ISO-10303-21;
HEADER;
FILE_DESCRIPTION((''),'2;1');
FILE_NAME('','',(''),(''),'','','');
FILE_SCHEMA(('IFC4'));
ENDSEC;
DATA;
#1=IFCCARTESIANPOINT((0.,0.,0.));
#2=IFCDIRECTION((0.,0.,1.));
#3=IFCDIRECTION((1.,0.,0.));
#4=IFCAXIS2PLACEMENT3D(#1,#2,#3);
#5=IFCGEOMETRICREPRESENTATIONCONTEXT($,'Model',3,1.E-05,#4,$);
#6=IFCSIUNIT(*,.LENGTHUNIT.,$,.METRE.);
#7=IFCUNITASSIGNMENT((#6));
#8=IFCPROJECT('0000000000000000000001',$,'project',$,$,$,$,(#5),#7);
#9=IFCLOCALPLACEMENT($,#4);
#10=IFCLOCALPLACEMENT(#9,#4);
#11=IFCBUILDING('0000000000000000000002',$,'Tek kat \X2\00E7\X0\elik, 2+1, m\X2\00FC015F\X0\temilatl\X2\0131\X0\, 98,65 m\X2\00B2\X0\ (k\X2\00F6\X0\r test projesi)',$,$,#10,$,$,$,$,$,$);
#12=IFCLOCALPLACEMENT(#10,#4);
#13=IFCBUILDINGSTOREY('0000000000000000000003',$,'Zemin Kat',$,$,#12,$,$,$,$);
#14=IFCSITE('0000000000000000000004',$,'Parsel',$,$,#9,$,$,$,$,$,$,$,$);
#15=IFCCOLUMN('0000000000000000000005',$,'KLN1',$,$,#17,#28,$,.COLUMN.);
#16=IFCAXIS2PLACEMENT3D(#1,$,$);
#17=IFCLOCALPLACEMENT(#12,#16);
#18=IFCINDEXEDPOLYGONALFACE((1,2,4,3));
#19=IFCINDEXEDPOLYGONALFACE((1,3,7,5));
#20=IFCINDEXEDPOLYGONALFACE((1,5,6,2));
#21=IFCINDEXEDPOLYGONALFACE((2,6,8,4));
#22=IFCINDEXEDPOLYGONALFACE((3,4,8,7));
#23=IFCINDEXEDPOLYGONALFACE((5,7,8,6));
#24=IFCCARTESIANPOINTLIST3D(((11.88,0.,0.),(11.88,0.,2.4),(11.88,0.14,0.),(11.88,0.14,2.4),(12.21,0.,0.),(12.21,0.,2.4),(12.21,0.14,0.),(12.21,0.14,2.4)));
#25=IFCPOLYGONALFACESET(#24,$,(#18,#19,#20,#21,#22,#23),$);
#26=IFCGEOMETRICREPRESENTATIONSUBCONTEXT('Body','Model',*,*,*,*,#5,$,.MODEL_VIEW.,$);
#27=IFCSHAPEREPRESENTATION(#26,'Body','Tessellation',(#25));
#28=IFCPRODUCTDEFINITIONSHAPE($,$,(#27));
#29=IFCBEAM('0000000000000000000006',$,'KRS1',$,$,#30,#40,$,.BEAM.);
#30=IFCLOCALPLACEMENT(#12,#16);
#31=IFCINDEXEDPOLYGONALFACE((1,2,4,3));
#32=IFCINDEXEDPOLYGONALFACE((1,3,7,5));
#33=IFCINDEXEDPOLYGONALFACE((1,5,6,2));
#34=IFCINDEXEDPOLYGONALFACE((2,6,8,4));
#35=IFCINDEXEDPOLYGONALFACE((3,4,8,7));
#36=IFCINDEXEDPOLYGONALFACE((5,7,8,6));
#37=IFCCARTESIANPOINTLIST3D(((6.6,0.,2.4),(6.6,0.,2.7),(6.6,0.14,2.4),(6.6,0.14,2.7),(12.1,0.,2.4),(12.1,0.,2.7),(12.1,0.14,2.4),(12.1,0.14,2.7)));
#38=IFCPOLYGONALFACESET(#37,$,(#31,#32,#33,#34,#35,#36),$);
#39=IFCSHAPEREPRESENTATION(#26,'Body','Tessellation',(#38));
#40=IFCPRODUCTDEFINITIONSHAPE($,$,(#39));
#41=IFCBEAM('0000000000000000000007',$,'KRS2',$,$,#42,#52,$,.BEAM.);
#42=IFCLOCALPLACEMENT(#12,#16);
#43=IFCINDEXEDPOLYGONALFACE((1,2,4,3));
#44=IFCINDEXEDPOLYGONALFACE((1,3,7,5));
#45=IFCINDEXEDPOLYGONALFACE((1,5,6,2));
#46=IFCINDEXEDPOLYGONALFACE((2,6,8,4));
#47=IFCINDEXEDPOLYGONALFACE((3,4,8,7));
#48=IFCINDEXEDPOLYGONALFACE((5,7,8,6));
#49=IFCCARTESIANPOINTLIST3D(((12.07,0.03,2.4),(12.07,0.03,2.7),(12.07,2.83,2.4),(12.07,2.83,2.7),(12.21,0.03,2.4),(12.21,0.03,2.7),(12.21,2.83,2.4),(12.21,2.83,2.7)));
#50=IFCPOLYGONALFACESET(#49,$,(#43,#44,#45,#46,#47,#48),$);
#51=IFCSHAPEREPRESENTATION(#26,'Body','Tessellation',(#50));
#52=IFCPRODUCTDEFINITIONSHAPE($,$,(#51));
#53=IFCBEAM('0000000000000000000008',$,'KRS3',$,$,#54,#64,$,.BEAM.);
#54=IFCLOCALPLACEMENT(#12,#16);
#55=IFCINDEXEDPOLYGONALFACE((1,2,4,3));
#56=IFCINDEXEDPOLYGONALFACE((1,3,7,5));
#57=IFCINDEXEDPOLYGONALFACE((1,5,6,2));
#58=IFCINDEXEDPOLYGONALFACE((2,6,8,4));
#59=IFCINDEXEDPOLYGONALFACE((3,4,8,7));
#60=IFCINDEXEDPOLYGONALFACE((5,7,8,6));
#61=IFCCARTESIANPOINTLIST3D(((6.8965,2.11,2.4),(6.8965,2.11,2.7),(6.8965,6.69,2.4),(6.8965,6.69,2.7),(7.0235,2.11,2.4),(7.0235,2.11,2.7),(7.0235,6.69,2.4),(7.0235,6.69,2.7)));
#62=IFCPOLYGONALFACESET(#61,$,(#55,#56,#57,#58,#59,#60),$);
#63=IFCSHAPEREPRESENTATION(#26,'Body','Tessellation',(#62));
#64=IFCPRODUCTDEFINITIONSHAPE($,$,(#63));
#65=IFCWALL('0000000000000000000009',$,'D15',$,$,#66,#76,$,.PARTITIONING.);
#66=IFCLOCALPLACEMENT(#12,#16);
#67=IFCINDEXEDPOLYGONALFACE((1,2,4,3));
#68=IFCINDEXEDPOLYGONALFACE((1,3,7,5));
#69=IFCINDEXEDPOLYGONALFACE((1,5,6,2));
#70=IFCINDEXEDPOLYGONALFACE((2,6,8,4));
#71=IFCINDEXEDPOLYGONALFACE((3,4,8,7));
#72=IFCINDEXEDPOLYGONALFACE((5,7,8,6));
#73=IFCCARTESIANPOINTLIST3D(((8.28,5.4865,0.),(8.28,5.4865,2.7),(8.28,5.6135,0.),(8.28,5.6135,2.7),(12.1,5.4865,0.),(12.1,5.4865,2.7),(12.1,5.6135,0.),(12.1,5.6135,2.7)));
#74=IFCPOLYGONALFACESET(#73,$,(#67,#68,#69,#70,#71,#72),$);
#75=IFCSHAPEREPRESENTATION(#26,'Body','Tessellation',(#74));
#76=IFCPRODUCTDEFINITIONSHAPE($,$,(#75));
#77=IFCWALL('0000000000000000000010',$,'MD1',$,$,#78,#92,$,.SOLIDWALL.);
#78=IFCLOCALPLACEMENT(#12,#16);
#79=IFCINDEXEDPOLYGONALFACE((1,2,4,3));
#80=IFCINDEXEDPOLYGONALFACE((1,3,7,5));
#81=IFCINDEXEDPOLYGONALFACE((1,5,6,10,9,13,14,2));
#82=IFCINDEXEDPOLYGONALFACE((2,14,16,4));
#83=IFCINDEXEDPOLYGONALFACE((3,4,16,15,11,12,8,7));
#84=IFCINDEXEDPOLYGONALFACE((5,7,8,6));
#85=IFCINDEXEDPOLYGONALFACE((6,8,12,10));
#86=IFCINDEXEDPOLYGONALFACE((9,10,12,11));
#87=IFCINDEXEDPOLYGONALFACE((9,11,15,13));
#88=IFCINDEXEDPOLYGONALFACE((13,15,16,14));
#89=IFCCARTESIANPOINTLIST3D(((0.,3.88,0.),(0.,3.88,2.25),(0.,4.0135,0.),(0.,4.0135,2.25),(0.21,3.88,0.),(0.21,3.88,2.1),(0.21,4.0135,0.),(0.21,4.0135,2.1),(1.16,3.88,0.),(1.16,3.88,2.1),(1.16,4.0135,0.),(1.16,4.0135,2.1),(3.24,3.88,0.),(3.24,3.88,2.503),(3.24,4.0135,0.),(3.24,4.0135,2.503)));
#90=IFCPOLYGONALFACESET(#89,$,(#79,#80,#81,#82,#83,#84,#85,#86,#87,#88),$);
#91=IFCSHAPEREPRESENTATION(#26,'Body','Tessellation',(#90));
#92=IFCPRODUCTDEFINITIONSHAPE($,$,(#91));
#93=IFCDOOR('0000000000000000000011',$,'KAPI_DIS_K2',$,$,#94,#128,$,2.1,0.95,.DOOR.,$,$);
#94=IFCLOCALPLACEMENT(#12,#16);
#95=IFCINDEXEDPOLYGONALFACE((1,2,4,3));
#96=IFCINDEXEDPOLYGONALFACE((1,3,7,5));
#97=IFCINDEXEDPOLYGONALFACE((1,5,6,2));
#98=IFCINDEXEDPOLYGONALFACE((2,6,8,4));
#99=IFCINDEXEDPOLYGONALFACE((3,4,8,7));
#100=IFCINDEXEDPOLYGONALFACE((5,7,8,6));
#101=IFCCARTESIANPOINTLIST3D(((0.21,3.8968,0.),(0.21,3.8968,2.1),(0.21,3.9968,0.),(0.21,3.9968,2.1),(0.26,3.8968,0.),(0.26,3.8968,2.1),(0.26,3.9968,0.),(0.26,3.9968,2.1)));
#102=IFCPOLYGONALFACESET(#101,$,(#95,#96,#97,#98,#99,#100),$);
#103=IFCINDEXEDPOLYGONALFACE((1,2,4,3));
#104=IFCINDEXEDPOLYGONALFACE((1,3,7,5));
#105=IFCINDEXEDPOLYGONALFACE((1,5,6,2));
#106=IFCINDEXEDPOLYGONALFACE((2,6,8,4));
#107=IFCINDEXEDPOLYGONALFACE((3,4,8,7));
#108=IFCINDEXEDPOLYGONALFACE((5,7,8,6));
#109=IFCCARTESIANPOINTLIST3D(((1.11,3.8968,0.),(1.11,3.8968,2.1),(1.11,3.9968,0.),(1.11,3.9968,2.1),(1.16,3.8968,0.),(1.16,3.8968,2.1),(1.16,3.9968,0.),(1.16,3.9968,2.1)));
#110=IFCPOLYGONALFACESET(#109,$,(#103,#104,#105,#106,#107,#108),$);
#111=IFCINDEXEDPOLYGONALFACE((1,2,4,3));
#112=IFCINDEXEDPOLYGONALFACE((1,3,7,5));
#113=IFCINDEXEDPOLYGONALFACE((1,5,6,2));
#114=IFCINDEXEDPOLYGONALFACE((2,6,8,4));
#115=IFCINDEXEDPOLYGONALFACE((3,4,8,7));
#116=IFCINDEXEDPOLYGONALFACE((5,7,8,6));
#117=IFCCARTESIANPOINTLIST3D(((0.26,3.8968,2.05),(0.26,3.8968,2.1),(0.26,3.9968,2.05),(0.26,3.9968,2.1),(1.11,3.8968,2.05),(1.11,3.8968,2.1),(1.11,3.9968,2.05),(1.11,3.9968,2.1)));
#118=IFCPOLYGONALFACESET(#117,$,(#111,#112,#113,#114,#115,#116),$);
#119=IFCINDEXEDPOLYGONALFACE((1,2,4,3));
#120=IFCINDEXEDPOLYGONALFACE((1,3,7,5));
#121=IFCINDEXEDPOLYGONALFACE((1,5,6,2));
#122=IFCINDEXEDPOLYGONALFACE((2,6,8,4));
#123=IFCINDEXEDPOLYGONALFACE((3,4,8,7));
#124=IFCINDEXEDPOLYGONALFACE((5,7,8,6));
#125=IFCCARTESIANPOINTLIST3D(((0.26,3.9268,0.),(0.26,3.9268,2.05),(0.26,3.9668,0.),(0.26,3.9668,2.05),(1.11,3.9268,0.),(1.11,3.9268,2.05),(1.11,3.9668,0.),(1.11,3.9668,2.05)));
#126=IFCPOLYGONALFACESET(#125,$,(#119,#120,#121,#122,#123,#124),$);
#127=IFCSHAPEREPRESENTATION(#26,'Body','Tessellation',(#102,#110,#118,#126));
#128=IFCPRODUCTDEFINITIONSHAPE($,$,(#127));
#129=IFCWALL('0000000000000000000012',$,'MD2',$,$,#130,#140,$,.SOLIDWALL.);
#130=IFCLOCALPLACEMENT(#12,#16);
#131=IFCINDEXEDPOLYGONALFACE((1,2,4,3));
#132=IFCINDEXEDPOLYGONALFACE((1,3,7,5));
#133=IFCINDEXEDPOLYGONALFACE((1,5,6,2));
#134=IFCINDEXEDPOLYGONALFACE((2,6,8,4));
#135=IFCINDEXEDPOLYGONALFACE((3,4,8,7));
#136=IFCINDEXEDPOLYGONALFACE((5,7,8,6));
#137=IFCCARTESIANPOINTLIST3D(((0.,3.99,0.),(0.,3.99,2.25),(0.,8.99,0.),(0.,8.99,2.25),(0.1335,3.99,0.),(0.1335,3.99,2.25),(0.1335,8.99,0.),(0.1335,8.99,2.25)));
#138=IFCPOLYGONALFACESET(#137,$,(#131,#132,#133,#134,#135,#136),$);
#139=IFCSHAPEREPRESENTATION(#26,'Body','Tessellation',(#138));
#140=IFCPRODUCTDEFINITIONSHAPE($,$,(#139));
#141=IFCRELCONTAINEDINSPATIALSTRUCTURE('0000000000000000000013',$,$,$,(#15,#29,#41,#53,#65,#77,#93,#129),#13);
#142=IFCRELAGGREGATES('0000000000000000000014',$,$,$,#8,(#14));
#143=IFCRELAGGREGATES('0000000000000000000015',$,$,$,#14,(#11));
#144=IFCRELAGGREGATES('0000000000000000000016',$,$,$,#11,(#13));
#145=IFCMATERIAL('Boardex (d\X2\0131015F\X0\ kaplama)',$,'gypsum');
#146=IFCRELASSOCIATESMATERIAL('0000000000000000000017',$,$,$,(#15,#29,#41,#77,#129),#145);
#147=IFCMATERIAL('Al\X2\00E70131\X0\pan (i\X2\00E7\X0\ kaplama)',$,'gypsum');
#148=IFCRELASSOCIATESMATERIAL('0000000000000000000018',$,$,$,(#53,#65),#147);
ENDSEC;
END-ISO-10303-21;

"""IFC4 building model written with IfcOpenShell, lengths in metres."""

from ifc_helpers import new_model, si_unit, frame, origin_with_axes, place, context, subcontext, project, spatial, line, indexed_curve, outline, extrude, material, element, fill, save


model = new_model("IFC4")

# Units and contexts
model_context = context("Model", 3, precision=1e-05, world=origin_with_axes())
body_context = subcontext(model_context, "Body", "Model", "MODEL_VIEW")
ifc_project = project(units=[si_unit("LENGTHUNIT", "METRE")], contexts=[model_context])

# Site, building, storey
site_placement = place(None, origin_with_axes())
site = spatial("IfcSite", under=ifc_project, at=site_placement, Name="Parsel")
building_placement = place(site_placement, origin_with_axes())
building = spatial("IfcBuilding", under=site, at=building_placement, Name="Tek kat çelik, 2+1, müştemilatlı, 98,65 m² (kör test projesi)")
storey_placement = place(building_placement, origin_with_axes())
storey = spatial("IfcBuildingStorey", under=building, at=storey_placement, Name="Zemin Kat")

# Column
ifc_material_1 = material(Name="Boardex (dış kaplama)", Category="gypsum")
column_placement = place(storey_placement, origin_with_axes())
element("IfcColumn", 1, at=column_placement, inside=storey, material=ifc_material_1, Name="KLN1", PredefinedType="COLUMN", context=body_context, shape_type="SweptSolid", body=[
    extrude(outline(indexed_curve([(0.0, 0.0), (0.33, 0.0), (0.33, 0.14), (0.0, 0.14)], segments=[line(1, 2, 3, 4, 1)])), frame((11.88, 0.0, 0.0), z_axis=(0.0, 0.0, 1.0), x_axis=(1.0, 0.0, 0.0)), (0.0, 0.0, 1.0), 2.4),
])

# Beams
beam_1_placement = place(storey_placement, origin_with_axes())
element("IfcBeam", 2, at=beam_1_placement, inside=storey, material=ifc_material_1, Name="KRS1", PredefinedType="BEAM", context=body_context, shape_type="SweptSolid", body=[
    extrude(outline(indexed_curve([(0.0, 0.0), (5.5, 0.0), (5.5, 0.14), (0.0, 0.14)], segments=[line(1, 2, 3, 4, 1)])), frame((6.6, 0.0, 2.4), z_axis=(0.0, 0.0, 1.0), x_axis=(1.0, 0.0, 0.0)), (0.0, 0.0, 1.0), 0.3),
])
beam_2_placement = place(storey_placement, origin_with_axes())
element("IfcBeam", 3, at=beam_2_placement, inside=storey, material=ifc_material_1, Name="KRS2", PredefinedType="BEAM", context=body_context, shape_type="SweptSolid", body=[
    extrude(outline(indexed_curve([(0.0, 0.0), (0.14, 0.0), (0.14, 2.8), (0.0, 2.8)], segments=[line(1, 2, 3, 4, 1)])), frame((12.07, 0.03, 2.4), z_axis=(0.0, 0.0, 1.0), x_axis=(1.0, 0.0, 0.0)), (0.0, 0.0, 1.0), 0.3),
])
ifc_material_2 = material(Name="Alçıpan (iç kaplama)", Category="gypsum")
beam_3_placement = place(storey_placement, origin_with_axes())
element("IfcBeam", 4, at=beam_3_placement, inside=storey, material=ifc_material_2, Name="KRS3", PredefinedType="BEAM", context=body_context, shape_type="SweptSolid", body=[
    extrude(outline(indexed_curve([(0.0, 0.0), (0.127, 0.0), (0.127, 4.58), (0.0, 4.58)], segments=[line(1, 2, 3, 4, 1)])), frame((6.8965, 2.11, 2.4), z_axis=(0.0, 0.0, 1.0), x_axis=(1.0, 0.0, 0.0)), (0.0, 0.0, 1.0), 0.3),
])

# Wall
wall_1_placement = place(storey_placement, origin_with_axes())
element("IfcWall", 5, at=wall_1_placement, inside=storey, material=ifc_material_2, Name="D15", PredefinedType="PARTITIONING", context=body_context, shape_type="SweptSolid", body=[
    extrude(outline(indexed_curve([(0.0, 0.0), (3.82, 0.0), (3.82, 0.127), (0.0, 0.127)], segments=[line(1, 2, 3, 4, 1)])), frame((8.28, 5.4865, 0.0), z_axis=(0.0, 0.0, 1.0), x_axis=(1.0, 0.0, 0.0)), (0.0, 0.0, 1.0), 2.7),
])

# Wall, opening, door
wall_2_placement = place(storey_placement, origin_with_axes())
wall_2 = element("IfcWall", 6, at=wall_2_placement, inside=storey, material=ifc_material_1, Name="MD1", PredefinedType="SOLIDWALL", context=body_context, shape_type="SweptSolid", body=[
    extrude(outline(indexed_curve([(0.0, 0.0), (3.24, 0.0), (3.24, 2.503), (0.0, 2.25)], segments=[line(1, 2, 3, 4, 1)])), frame((0.0, 4.0135, 0.0), z_axis=(0.0, -1.0, 0.0), x_axis=(1.0, 0.0, 0.0)), (0.0, 0.0, 1.0), 0.1335),
])
opening_1_placement = place(wall_2_placement, origin_with_axes())
opening_1 = element("IfcOpeningElement", 7, at=opening_1_placement, cuts=wall_2, PredefinedType="OPENING", context=body_context, shape_type="SweptSolid", body=[
    extrude(outline(indexed_curve([(0.0, 0.0), (0.95, 0.0), (0.95, 0.1735), (0.0, 0.1735)], segments=[line(1, 2, 3, 4, 1)])), frame((0.21, 3.86, 0.0), z_axis=(0.0, 0.0, 1.0), x_axis=(1.0, 0.0, 0.0)), (0.0, 0.0, 1.0), 2.1),
])
door_placement = place(storey_placement, origin_with_axes())
door = element("IfcDoor", 8, at=door_placement, inside=storey, Name="KAPI_DIS_K2", OverallHeight=2.1, OverallWidth=0.95, PredefinedType="DOOR", context=body_context, shape_type="SweptSolid", body=[
    extrude(outline(indexed_curve([(0.0, 0.0), (0.05, 0.0), (0.05, 0.1), (0.0, 0.1)], segments=[line(1, 2, 3, 4, 1)])), frame((0.21, 3.8968, 0.0), z_axis=(0.0, 0.0, 1.0), x_axis=(1.0, 0.0, 0.0)), (0.0, 0.0, 1.0), 2.1),
    extrude(outline(indexed_curve([(0.0, 0.0), (0.05, 0.0), (0.05, 0.1), (0.0, 0.1)], segments=[line(1, 2, 3, 4, 1)])), frame((1.11, 3.8968, 0.0), z_axis=(0.0, 0.0, 1.0), x_axis=(1.0, 0.0, 0.0)), (0.0, 0.0, 1.0), 2.1),
    extrude(outline(indexed_curve([(0.0, 0.0), (0.85, 0.0), (0.85, 0.1), (0.0, 0.1)], segments=[line(1, 2, 3, 4, 1)])), frame((0.26, 3.8968, 2.05), z_axis=(0.0, 0.0, 1.0), x_axis=(1.0, 0.0, 0.0)), (0.0, 0.0, 1.0), 0.05),
    extrude(outline(indexed_curve([(0.0, 0.0), (0.85, 0.0), (0.85, 0.04), (0.0, 0.04)], segments=[line(1, 2, 3, 4, 1)])), frame((0.26, 3.9268, 0.0), z_axis=(0.0, 0.0, 1.0), x_axis=(1.0, 0.0, 0.0)), (0.0, 0.0, 1.0), 2.05),
])
fill(opening_1, door)

# Wall
wall_3_placement = place(storey_placement, origin_with_axes())
element("IfcWall", 9, at=wall_3_placement, inside=storey, material=ifc_material_1, Name="MD2", PredefinedType="SOLIDWALL", context=body_context, shape_type="SweptSolid", body=[
    extrude(outline(indexed_curve([(0.0, 0.0), (0.1335, 0.0), (0.1335, 5.0), (0.0, 5.0)], segments=[line(1, 2, 3, 4, 1)])), frame((0.0, 3.99, 0.0), z_axis=(0.0, 0.0, 1.0), x_axis=(1.0, 0.0, 0.0)), (0.0, 0.0, 1.0), 2.25),
])

save(model, "model.ifc")
